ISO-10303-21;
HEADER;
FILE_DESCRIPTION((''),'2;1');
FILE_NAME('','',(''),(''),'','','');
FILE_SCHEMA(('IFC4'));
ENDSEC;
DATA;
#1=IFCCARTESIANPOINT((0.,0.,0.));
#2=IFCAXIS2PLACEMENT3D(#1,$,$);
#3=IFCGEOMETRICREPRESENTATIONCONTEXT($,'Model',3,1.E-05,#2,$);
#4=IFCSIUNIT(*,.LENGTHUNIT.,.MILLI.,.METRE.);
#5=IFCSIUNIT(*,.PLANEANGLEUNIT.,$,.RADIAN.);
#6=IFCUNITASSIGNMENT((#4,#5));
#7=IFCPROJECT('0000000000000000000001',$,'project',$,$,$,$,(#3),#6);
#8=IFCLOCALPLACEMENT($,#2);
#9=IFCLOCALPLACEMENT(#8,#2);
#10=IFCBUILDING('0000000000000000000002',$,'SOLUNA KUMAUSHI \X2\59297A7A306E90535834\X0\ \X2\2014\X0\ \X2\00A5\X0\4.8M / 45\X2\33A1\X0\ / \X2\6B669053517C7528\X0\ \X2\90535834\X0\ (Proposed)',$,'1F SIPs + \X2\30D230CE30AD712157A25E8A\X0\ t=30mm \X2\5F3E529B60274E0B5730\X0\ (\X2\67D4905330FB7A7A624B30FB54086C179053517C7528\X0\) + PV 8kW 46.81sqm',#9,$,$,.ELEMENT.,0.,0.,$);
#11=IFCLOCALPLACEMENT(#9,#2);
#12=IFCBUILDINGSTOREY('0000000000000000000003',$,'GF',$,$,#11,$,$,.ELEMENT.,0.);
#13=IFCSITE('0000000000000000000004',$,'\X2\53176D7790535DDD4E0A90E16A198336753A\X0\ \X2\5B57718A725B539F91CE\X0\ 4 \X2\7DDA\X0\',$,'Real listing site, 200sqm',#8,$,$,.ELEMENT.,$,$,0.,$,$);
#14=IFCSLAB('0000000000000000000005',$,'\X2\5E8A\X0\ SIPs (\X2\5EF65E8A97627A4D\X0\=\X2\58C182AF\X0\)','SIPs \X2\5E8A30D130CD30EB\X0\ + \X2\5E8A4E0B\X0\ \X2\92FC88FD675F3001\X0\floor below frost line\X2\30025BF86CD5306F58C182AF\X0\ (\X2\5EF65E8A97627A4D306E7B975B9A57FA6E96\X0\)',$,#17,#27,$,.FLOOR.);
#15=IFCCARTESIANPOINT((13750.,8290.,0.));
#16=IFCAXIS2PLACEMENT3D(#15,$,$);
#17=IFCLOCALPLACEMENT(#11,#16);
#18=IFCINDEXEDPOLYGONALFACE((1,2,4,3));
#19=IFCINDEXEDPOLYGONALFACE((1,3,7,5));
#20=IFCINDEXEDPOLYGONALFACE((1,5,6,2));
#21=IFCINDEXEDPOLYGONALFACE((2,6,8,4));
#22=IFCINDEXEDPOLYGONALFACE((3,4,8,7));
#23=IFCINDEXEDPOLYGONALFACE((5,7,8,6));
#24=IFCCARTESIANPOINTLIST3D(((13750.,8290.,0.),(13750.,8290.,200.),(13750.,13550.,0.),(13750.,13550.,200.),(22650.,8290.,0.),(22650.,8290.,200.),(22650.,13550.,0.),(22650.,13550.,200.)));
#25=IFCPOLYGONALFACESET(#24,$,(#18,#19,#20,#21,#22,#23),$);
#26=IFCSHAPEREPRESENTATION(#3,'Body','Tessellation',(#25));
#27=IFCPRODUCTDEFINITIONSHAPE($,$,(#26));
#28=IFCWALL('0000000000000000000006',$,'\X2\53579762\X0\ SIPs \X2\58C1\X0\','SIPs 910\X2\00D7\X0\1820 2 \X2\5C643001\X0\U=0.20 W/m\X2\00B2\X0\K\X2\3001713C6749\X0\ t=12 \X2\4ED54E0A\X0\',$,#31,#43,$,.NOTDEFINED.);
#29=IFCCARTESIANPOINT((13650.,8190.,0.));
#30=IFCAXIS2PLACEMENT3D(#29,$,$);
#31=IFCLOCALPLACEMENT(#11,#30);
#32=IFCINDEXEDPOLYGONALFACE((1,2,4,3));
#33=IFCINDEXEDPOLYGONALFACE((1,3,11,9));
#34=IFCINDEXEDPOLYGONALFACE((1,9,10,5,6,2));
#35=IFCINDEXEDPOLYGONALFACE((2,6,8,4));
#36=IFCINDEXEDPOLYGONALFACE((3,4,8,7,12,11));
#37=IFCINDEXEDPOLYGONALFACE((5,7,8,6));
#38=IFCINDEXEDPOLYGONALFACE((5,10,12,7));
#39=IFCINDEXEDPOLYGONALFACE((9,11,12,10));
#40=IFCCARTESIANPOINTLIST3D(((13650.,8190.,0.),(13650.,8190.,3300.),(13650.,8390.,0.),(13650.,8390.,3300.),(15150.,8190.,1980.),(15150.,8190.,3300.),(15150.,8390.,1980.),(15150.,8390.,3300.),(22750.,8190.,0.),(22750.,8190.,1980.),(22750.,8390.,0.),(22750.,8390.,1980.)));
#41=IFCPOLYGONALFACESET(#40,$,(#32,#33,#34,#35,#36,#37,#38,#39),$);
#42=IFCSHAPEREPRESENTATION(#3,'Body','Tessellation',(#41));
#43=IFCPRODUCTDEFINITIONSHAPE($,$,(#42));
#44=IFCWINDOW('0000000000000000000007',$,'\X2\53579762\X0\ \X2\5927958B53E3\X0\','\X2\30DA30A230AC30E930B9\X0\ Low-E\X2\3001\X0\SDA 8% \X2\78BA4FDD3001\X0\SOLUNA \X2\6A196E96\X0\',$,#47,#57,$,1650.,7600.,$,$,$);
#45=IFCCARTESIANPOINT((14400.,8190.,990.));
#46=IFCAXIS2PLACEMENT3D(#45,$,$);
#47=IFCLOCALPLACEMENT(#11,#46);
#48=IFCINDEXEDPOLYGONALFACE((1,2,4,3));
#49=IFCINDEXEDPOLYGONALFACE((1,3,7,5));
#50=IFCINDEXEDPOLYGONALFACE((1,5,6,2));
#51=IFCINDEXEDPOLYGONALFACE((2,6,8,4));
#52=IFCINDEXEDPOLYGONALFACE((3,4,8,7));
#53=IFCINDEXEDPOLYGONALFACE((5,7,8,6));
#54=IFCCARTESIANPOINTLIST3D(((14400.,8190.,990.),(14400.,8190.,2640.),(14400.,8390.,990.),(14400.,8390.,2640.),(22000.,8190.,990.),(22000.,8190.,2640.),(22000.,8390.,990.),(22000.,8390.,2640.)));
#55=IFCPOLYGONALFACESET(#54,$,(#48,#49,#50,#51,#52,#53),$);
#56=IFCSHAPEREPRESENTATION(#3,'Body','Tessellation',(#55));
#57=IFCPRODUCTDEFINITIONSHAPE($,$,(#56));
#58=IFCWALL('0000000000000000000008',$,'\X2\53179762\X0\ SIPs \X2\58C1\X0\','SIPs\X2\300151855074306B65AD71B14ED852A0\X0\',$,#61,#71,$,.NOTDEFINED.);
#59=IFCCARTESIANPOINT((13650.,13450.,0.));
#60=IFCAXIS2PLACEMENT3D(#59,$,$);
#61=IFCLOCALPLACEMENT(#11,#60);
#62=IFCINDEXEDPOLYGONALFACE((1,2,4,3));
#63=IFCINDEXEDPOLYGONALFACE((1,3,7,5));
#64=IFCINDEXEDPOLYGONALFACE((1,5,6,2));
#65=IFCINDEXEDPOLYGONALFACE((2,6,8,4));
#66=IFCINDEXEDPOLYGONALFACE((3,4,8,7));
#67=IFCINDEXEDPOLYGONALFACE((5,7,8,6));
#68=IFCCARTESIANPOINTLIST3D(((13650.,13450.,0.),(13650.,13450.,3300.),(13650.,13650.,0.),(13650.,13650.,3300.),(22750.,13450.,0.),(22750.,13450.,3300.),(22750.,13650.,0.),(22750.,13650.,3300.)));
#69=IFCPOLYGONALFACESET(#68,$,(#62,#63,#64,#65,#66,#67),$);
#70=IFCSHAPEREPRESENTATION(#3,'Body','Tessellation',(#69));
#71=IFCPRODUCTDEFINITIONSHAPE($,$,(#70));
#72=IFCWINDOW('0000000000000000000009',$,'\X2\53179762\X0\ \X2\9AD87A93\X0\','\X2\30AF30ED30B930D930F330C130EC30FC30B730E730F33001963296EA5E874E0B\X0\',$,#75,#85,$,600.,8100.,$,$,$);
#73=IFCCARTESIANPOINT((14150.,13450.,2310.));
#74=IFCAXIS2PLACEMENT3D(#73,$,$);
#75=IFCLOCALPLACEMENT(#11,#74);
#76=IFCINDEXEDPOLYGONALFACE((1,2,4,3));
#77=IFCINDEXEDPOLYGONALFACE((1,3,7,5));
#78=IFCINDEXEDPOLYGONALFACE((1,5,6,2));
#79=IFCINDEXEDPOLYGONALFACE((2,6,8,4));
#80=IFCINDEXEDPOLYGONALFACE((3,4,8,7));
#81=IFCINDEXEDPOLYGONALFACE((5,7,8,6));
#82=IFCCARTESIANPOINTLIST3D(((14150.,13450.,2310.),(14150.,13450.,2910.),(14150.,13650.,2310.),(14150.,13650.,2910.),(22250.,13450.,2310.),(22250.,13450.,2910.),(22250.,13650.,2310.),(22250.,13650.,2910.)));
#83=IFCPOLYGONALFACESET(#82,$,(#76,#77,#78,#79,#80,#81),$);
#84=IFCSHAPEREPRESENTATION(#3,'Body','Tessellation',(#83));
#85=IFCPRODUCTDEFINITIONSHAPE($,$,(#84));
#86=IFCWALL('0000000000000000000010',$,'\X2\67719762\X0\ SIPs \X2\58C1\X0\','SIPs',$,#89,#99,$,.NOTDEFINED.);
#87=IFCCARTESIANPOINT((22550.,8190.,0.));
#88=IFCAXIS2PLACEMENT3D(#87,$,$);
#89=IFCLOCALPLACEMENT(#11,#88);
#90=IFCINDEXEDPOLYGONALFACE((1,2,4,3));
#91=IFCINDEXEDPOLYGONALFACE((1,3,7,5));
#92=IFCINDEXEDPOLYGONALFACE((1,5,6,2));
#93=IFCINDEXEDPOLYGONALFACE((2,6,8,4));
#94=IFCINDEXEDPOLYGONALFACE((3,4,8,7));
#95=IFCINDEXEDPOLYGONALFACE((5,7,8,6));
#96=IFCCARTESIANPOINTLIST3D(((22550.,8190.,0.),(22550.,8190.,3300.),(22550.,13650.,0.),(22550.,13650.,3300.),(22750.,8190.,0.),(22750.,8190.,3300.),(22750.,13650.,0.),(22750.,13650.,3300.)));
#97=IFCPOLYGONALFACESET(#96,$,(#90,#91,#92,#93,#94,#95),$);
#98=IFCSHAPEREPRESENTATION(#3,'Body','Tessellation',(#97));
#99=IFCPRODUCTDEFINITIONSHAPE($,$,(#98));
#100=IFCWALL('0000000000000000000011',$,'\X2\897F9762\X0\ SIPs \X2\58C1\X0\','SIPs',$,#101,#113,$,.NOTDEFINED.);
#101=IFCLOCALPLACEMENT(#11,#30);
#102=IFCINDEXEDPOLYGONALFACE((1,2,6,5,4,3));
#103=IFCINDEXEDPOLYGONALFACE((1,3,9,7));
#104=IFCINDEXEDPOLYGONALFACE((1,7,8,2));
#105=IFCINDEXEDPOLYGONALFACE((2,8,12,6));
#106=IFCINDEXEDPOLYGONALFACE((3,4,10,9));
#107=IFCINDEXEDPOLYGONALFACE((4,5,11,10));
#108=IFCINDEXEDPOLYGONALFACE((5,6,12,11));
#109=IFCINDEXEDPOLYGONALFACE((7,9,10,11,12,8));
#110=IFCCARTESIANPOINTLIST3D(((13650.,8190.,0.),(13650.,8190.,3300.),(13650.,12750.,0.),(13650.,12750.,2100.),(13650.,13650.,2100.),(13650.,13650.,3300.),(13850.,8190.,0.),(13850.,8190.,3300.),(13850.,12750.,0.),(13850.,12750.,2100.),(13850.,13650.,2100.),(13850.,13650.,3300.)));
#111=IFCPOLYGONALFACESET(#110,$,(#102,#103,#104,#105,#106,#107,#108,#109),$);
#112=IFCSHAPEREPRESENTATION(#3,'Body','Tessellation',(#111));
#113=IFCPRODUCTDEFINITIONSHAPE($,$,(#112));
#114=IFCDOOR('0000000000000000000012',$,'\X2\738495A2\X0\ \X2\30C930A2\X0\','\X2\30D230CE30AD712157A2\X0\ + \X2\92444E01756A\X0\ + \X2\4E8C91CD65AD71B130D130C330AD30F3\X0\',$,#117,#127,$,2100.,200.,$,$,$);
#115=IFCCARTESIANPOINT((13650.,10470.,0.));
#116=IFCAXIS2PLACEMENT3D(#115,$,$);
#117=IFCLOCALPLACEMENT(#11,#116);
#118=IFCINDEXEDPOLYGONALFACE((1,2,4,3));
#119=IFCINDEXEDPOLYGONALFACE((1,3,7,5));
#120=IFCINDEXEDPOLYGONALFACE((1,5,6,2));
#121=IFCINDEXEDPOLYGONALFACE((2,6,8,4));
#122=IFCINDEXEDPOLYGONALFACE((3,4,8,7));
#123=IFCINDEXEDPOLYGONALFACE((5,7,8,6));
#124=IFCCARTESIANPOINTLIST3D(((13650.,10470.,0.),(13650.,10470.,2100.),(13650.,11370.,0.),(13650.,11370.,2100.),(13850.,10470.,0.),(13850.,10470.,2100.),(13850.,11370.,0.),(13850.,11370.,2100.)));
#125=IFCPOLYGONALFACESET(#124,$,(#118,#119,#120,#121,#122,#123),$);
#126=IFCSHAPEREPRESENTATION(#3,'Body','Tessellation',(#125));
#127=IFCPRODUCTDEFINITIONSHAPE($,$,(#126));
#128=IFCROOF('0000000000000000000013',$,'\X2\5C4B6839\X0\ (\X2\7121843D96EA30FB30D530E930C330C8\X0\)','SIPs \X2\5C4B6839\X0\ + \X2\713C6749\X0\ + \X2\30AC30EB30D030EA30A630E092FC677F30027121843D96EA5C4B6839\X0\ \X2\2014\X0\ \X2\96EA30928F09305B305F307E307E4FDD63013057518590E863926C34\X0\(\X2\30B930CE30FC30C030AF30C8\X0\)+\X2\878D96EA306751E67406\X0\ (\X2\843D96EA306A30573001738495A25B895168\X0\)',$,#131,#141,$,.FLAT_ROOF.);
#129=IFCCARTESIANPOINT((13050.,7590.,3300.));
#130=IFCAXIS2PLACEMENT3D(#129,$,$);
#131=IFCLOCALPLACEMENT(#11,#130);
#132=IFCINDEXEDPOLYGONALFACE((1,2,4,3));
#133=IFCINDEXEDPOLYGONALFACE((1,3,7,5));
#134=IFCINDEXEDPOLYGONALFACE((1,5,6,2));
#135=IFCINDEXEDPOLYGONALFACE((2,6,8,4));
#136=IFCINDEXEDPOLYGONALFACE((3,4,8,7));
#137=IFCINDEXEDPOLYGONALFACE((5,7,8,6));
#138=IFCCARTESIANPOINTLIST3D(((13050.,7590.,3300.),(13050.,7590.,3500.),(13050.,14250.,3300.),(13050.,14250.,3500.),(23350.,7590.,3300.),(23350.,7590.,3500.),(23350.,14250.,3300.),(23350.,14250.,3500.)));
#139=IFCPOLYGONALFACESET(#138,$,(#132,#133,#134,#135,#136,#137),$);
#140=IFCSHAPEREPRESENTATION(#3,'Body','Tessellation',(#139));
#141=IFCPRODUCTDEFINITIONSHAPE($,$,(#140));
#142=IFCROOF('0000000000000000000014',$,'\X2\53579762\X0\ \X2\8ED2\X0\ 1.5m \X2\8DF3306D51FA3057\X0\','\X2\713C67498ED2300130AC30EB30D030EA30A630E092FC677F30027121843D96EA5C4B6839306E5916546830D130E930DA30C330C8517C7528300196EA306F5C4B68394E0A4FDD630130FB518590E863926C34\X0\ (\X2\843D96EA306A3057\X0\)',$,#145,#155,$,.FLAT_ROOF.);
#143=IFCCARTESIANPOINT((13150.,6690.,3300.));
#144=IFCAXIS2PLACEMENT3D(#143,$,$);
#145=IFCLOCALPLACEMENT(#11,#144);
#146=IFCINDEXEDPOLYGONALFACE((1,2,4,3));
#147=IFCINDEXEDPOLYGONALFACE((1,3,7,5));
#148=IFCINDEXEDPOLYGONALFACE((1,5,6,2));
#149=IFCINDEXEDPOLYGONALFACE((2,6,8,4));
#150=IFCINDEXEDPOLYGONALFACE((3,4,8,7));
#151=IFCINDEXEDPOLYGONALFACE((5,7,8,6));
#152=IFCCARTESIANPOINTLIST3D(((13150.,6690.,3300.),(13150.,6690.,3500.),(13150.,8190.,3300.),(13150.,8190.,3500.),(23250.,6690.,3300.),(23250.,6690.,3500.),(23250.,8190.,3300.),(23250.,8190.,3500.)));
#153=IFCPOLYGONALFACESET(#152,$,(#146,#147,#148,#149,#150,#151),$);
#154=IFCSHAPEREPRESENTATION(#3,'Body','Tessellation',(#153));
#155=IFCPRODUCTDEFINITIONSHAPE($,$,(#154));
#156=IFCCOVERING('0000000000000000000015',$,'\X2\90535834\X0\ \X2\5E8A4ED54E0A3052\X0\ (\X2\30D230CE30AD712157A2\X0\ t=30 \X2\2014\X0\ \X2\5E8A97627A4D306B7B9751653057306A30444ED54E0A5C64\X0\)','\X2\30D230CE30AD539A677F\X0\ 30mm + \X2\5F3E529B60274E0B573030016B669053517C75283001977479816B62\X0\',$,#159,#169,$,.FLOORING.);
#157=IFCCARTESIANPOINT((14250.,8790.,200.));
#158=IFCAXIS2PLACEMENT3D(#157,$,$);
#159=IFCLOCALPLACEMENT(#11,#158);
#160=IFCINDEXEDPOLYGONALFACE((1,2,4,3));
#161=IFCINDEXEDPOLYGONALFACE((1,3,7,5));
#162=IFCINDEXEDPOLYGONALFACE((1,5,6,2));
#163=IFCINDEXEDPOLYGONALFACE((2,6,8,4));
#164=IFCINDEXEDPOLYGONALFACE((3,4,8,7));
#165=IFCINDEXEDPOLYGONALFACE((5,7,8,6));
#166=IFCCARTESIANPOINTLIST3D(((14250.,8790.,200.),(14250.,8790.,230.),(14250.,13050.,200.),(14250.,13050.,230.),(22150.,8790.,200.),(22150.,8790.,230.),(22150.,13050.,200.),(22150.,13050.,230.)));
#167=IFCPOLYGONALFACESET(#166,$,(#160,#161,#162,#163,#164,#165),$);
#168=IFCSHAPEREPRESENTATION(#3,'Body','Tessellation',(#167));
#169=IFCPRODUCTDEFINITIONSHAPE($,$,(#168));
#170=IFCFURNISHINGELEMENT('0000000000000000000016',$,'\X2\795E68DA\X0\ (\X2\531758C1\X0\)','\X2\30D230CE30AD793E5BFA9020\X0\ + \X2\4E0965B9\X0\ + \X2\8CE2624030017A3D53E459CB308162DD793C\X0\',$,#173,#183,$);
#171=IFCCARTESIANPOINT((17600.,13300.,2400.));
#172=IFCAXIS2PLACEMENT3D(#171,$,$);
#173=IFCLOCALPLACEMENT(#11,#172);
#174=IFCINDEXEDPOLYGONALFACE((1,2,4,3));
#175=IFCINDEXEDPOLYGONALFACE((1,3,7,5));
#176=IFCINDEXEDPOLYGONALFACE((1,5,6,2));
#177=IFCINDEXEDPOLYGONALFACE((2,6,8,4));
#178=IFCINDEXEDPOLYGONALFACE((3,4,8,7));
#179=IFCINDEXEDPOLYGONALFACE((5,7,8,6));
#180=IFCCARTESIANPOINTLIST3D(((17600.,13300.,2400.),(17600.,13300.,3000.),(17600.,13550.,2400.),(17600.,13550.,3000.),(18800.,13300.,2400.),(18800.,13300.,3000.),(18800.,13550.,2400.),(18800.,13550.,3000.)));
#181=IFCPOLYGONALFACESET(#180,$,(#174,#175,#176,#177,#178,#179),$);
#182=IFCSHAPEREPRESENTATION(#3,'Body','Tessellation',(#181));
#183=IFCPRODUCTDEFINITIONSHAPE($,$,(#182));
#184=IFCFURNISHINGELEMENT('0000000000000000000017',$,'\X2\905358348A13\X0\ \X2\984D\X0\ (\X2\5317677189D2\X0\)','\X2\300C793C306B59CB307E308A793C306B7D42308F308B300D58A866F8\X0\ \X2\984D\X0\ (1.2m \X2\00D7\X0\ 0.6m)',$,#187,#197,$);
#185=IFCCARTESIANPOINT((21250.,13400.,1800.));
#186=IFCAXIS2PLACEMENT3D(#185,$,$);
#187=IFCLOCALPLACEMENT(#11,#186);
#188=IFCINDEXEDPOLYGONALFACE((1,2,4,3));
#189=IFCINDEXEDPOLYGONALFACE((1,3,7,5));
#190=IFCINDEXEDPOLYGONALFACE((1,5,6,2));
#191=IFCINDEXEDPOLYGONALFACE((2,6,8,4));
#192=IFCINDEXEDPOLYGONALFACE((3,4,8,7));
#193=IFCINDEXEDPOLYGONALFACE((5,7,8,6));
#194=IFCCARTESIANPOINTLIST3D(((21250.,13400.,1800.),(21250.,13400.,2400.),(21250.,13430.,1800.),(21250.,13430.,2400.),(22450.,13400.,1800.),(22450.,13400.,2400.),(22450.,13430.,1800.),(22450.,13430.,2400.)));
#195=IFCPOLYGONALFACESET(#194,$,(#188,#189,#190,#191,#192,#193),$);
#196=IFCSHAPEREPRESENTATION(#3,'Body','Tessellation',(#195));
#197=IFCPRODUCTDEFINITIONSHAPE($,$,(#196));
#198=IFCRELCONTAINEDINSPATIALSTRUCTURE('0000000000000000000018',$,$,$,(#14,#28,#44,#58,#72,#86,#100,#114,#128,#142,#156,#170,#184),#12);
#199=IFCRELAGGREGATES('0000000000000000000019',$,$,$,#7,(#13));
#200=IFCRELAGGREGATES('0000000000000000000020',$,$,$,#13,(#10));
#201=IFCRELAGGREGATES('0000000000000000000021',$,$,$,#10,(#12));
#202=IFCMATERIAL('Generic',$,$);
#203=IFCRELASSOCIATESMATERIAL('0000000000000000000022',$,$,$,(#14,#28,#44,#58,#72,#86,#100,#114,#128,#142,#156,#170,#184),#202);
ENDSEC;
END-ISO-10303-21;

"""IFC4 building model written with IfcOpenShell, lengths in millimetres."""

from ifc_helpers import new_model, si_unit, frame, frame_2d, origin, place, context, project, spatial, rectangle, extrude, material, element, fill, save


model = new_model("IFC4")

# Units and contexts
model_context = context("Model", 3, precision=1e-05, world=origin())
ifc_project = project(units=[si_unit("LENGTHUNIT", "METRE", prefix="MILLI"), si_unit("PLANEANGLEUNIT", "RADIAN")], contexts=[model_context])

# Site, building, storey
site_placement = place(None, origin())
site = spatial("IfcSite", under=ifc_project, at=site_placement, Name="北海道川上郡標茶町 字熊牛原野 4 線", ObjectType="Real listing site, 200sqm", CompositionType="ELEMENT", RefElevation=0.0)
building_placement = place(site_placement, origin())
building = spatial("IfcBuilding", under=site, at=building_placement, Name="SOLUNA KUMAUSHI 天空の道場 — ¥4.8M / 45㎡ / 武道兼用 道場 (Proposed)", ObjectType="1F SIPs + ヒノキ無垢床 t=30mm 弾力性下地 (柔道・空手・合気道兼用) + PV 8kW 46.81sqm", CompositionType="ELEMENT", ElevationOfRefHeight=0.0, ElevationOfTerrain=0.0)
storey_placement = place(building_placement, origin())
storey = spatial("IfcBuildingStorey", under=building, at=storey_placement, Name="GF", CompositionType="ELEMENT", Elevation=0.0)

# Slab
ifc_material = material(Name="Generic")
slab_placement = place(storey_placement, frame((13750.0, 8290.0, 0.0)))
element("IfcSlab", 1, at=slab_placement, inside=storey, material=ifc_material, Name="床 SIPs (延床面積=壁芯)", Description="SIPs 床パネル + 床下 鋼製束、floor below frost line。寸法は壁芯 (延床面積の算定基準)", PredefinedType="FLOOR", context=model_context, shape_type="SweptSolid", body=[
    extrude(rectangle(XDim=8900.0, YDim=5260.0, at=frame_2d((4450.0, 2630.0))), frame((13750.0, 8290.0, 0.0)), (0.0, 0.0, 1.0), 200.0),
])

# Walls, openings, windows
wall_1_placement = place(storey_placement, frame((13650.0, 8190.0, 0.0)))
wall_1 = element("IfcWall", 2, at=wall_1_placement, inside=storey, material=ifc_material, Name="南面 SIPs 壁", Description="SIPs 910×1820 2 層、U=0.20 W/m²K、焼杉 t=12 仕上", PredefinedType="NOTDEFINED", context=model_context, shape_type="SweptSolid", body=[
    extrude(rectangle(XDim=9100.0, YDim=200.0, at=frame_2d((4550.0, 100.0))), frame((13650.0, 8190.0, 0.0)), (0.0, 0.0, 1.0), 3300.0),
])
opening_1_placement = place(storey_placement, frame((14400.0, 8190.0, 990.0)))
opening_1 = element("IfcOpeningElement", 3, at=opening_1_placement, cuts=wall_1, PredefinedType="NOTDEFINED", context=model_context, shape_type="SweptSolid", body=[
    extrude(rectangle(XDim=7600.0, YDim=200.0, at=frame_2d((3800.0, 100.0))), frame((14400.0, 8190.0, 990.0)), (0.0, 0.0, 1.0), 1650.0),
])
window_1_placement = place(storey_placement, frame((14400.0, 8190.0, 990.0)))
window_1 = element("IfcWindow", 4, at=window_1_placement, inside=storey, material=ifc_material, Name="南面 大開口", Description="ペアガラス Low-E、SDA 8% 確保、SOLUNA 標準", OverallHeight=1650.0, OverallWidth=7600.0, context=model_context, shape_type="SweptSolid", body=[
    extrude(rectangle(XDim=7600.0, YDim=200.0, at=frame_2d((3800.0, 100.0))), frame((14400.0, 8190.0, 990.0)), (0.0, 0.0, 1.0), 1650.0),
])
fill(opening_1, window_1)
wall_2_placement = place(storey_placement, frame((13650.0, 13450.0, 0.0)))
wall_2 = element("IfcWall", 5, at=wall_2_placement, inside=storey, material=ifc_material, Name="北面 SIPs 壁", Description="SIPs、内側に断熱付加", PredefinedType="NOTDEFINED", context=model_context, shape_type="SweptSolid", body=[
    extrude(rectangle(XDim=9100.0, YDim=200.0, at=frame_2d((4550.0, 100.0))), frame((13650.0, 13450.0, 0.0)), (0.0, 0.0, 1.0), 3300.0),
])
opening_2_placement = place(storey_placement, frame((14150.0, 13450.0, 2310.0)))
opening_2 = element("IfcOpeningElement", 6, at=opening_2_placement, cuts=wall_2, PredefinedType="NOTDEFINED", context=model_context, shape_type="SweptSolid", body=[
    extrude(rectangle(XDim=8100.0, YDim=200.0, at=frame_2d((4050.0, 100.0))), frame((14150.0, 13450.0, 2310.0)), (0.0, 0.0, 1.0), 600.0),
])
window_2_placement = place(storey_placement, frame((14150.0, 13450.0, 2310.0)))
window_2 = element("IfcWindow", 7, at=window_2_placement, inside=storey, material=ifc_material, Name="北面 高窓", Description="クロスベンチレーション、防雪庇下", OverallHeight=600.0, OverallWidth=8100.0, context=model_context, shape_type="SweptSolid", body=[
    extrude(rectangle(XDim=8100.0, YDim=200.0, at=frame_2d((4050.0, 100.0))), frame((14150.0, 13450.0, 2310.0)), (0.0, 0.0, 1.0), 600.0),
])
fill(opening_2, window_2)

# Wall
wall_3_placement = place(storey_placement, frame((22550.0, 8190.0, 0.0)))
element("IfcWall", 8, at=wall_3_placement, inside=storey, material=ifc_material, Name="東面 SIPs 壁", Description="SIPs", PredefinedType="NOTDEFINED", context=model_context, shape_type="SweptSolid", body=[
    extrude(rectangle(XDim=200.0, YDim=5460.0, at=frame_2d((100.0, 2730.0))), frame((22550.0, 8190.0, 0.0)), (0.0, 0.0, 1.0), 3300.0),
])

# Wall, opening, door
wall_4_placement = place(storey_placement, frame((13650.0, 8190.0, 0.0)))
wall_4 = element("IfcWall", 9, at=wall_4_placement, inside=storey, material=ifc_material, Name="西面 SIPs 壁", Description="SIPs", PredefinedType="NOTDEFINED", context=model_context, shape_type="SweptSolid", body=[
    extrude(rectangle(XDim=200.0, YDim=5460.0, at=frame_2d((100.0, 2730.0))), frame((13650.0, 8190.0, 0.0)), (0.0, 0.0, 1.0), 3300.0),
])
opening_3_placement = place(storey_placement, frame((13650.0, 10470.0, 0.0)))
opening_3 = element("IfcOpeningElement", 10, at=opening_3_placement, cuts=wall_4, PredefinedType="NOTDEFINED", context=model_context, shape_type="SweptSolid", body=[
    extrude(rectangle(XDim=200.0, YDim=900.0, at=frame_2d((100.0, 450.0))), frame((13650.0, 10470.0, 0.0)), (0.0, 0.0, 1.0), 2100.0),
])
door_placement = place(storey_placement, frame((13650.0, 10470.0, 0.0)))
door = element("IfcDoor", 11, at=door_placement, inside=storey, material=ifc_material, Name="玄関 ドア", Description="ヒノキ無垢 + 鉄丁番 + 二重断熱パッキン", OverallHeight=2100.0, OverallWidth=200.0, context=model_context, shape_type="SweptSolid", body=[
    extrude(rectangle(XDim=200.0, YDim=900.0, at=frame_2d((100.0, 450.0))), frame((13650.0, 10470.0, 0.0)), (0.0, 0.0, 1.0), 2100.0),
])
fill(opening_3, door)

# Roofs
roof_1_placement = place(storey_placement, frame((13050.0, 7590.0, 3300.0)))
element("IfcRoof", 12, at=roof_1_placement, inside=storey, material=ifc_material, Name="屋根 (無落雪・フラット)", Description="SIPs 屋根 + 焼杉 + ガルバリウム鋼板。無落雪屋根 — 雪を載せたまま保持し内部排水(スノーダクト)+融雪で処理 (落雪なし、玄関安全)", PredefinedType="FLAT_ROOF", context=model_context, shape_type="SweptSolid", body=[
    extrude(rectangle(XDim=10300.0, YDim=6660.0, at=frame_2d((5150.0, 3330.0))), frame((13050.0, 7590.0, 3300.0)), (0.0, 0.0, 1.0), 200.0),
])
roof_2_placement = place(storey_placement, frame((13150.0, 6690.0, 3300.0)))
element("IfcRoof", 13, at=roof_2_placement, inside=storey, material=ifc_material, Name="南面 軒 1.5m 跳ね出し", Description="焼杉軒、ガルバリウム鋼板。無落雪屋根の外周パラペット兼用、雪は屋根上保持・内部排水 (落雪なし)", PredefinedType="FLAT_ROOF", context=model_context, shape_type="SweptSolid", body=[
    extrude(rectangle(XDim=10100.0, YDim=1500.0, at=frame_2d((5050.0, 750.0))), frame((13150.0, 6690.0, 3300.0)), (0.0, 0.0, 1.0), 200.0),
])

# Covering
covering_placement = place(storey_placement, frame((14250.0, 8790.0, 200.0)))
element("IfcCovering", 14, at=covering_placement, inside=storey, material=ifc_material, Name="道場 床仕上げ (ヒノキ無垢 t=30 — 床面積に算入しない仕上層)", Description="ヒノキ厚板 30mm + 弾力性下地、武道兼用、靴禁止", PredefinedType="FLOORING", context=model_context, shape_type="SweptSolid", body=[
    extrude(rectangle(XDim=7900.0, YDim=4260.0, at=frame_2d((3950.0, 2130.0))), frame((14250.0, 8790.0, 200.0)), (0.0, 0.0, 1.0), 30.0),
])

# Furnishing elements
furnishing_1_placement = place(storey_placement, frame((17600.0, 13300.0, 2400.0)))
element("IfcFurnishingElement", 15, at=furnishing_1_placement, inside=storey, material=ifc_material, Name="神棚 (北壁)", Description="ヒノキ社寺造 + 三方 + 賢所、稽古始め拝礼", context=model_context, shape_type="SweptSolid", body=[
    extrude(rectangle(XDim=1200.0, YDim=250.0, at=frame_2d((600.0, 125.0))), frame((17600.0, 13300.0, 2400.0)), (0.0, 0.0, 1.0), 600.0),
])
furnishing_2_placement = place(storey_placement, frame((21250.0, 13400.0, 1800.0)))
element("IfcFurnishingElement", 16, at=furnishing_2_placement, inside=storey, material=ifc_material, Name="道場訓 額 (北東角)", Description="「礼に始まり礼に終わる」墨書 額 (1.2m × 0.6m)", context=model_context, shape_type="SweptSolid", body=[
    extrude(rectangle(XDim=1200.0, YDim=30.0, at=frame_2d((600.0, 15.0))), frame((21250.0, 13400.0, 1800.0)), (0.0, 0.0, 1.0), 600.0),
])

save(model, "model.ifc")
